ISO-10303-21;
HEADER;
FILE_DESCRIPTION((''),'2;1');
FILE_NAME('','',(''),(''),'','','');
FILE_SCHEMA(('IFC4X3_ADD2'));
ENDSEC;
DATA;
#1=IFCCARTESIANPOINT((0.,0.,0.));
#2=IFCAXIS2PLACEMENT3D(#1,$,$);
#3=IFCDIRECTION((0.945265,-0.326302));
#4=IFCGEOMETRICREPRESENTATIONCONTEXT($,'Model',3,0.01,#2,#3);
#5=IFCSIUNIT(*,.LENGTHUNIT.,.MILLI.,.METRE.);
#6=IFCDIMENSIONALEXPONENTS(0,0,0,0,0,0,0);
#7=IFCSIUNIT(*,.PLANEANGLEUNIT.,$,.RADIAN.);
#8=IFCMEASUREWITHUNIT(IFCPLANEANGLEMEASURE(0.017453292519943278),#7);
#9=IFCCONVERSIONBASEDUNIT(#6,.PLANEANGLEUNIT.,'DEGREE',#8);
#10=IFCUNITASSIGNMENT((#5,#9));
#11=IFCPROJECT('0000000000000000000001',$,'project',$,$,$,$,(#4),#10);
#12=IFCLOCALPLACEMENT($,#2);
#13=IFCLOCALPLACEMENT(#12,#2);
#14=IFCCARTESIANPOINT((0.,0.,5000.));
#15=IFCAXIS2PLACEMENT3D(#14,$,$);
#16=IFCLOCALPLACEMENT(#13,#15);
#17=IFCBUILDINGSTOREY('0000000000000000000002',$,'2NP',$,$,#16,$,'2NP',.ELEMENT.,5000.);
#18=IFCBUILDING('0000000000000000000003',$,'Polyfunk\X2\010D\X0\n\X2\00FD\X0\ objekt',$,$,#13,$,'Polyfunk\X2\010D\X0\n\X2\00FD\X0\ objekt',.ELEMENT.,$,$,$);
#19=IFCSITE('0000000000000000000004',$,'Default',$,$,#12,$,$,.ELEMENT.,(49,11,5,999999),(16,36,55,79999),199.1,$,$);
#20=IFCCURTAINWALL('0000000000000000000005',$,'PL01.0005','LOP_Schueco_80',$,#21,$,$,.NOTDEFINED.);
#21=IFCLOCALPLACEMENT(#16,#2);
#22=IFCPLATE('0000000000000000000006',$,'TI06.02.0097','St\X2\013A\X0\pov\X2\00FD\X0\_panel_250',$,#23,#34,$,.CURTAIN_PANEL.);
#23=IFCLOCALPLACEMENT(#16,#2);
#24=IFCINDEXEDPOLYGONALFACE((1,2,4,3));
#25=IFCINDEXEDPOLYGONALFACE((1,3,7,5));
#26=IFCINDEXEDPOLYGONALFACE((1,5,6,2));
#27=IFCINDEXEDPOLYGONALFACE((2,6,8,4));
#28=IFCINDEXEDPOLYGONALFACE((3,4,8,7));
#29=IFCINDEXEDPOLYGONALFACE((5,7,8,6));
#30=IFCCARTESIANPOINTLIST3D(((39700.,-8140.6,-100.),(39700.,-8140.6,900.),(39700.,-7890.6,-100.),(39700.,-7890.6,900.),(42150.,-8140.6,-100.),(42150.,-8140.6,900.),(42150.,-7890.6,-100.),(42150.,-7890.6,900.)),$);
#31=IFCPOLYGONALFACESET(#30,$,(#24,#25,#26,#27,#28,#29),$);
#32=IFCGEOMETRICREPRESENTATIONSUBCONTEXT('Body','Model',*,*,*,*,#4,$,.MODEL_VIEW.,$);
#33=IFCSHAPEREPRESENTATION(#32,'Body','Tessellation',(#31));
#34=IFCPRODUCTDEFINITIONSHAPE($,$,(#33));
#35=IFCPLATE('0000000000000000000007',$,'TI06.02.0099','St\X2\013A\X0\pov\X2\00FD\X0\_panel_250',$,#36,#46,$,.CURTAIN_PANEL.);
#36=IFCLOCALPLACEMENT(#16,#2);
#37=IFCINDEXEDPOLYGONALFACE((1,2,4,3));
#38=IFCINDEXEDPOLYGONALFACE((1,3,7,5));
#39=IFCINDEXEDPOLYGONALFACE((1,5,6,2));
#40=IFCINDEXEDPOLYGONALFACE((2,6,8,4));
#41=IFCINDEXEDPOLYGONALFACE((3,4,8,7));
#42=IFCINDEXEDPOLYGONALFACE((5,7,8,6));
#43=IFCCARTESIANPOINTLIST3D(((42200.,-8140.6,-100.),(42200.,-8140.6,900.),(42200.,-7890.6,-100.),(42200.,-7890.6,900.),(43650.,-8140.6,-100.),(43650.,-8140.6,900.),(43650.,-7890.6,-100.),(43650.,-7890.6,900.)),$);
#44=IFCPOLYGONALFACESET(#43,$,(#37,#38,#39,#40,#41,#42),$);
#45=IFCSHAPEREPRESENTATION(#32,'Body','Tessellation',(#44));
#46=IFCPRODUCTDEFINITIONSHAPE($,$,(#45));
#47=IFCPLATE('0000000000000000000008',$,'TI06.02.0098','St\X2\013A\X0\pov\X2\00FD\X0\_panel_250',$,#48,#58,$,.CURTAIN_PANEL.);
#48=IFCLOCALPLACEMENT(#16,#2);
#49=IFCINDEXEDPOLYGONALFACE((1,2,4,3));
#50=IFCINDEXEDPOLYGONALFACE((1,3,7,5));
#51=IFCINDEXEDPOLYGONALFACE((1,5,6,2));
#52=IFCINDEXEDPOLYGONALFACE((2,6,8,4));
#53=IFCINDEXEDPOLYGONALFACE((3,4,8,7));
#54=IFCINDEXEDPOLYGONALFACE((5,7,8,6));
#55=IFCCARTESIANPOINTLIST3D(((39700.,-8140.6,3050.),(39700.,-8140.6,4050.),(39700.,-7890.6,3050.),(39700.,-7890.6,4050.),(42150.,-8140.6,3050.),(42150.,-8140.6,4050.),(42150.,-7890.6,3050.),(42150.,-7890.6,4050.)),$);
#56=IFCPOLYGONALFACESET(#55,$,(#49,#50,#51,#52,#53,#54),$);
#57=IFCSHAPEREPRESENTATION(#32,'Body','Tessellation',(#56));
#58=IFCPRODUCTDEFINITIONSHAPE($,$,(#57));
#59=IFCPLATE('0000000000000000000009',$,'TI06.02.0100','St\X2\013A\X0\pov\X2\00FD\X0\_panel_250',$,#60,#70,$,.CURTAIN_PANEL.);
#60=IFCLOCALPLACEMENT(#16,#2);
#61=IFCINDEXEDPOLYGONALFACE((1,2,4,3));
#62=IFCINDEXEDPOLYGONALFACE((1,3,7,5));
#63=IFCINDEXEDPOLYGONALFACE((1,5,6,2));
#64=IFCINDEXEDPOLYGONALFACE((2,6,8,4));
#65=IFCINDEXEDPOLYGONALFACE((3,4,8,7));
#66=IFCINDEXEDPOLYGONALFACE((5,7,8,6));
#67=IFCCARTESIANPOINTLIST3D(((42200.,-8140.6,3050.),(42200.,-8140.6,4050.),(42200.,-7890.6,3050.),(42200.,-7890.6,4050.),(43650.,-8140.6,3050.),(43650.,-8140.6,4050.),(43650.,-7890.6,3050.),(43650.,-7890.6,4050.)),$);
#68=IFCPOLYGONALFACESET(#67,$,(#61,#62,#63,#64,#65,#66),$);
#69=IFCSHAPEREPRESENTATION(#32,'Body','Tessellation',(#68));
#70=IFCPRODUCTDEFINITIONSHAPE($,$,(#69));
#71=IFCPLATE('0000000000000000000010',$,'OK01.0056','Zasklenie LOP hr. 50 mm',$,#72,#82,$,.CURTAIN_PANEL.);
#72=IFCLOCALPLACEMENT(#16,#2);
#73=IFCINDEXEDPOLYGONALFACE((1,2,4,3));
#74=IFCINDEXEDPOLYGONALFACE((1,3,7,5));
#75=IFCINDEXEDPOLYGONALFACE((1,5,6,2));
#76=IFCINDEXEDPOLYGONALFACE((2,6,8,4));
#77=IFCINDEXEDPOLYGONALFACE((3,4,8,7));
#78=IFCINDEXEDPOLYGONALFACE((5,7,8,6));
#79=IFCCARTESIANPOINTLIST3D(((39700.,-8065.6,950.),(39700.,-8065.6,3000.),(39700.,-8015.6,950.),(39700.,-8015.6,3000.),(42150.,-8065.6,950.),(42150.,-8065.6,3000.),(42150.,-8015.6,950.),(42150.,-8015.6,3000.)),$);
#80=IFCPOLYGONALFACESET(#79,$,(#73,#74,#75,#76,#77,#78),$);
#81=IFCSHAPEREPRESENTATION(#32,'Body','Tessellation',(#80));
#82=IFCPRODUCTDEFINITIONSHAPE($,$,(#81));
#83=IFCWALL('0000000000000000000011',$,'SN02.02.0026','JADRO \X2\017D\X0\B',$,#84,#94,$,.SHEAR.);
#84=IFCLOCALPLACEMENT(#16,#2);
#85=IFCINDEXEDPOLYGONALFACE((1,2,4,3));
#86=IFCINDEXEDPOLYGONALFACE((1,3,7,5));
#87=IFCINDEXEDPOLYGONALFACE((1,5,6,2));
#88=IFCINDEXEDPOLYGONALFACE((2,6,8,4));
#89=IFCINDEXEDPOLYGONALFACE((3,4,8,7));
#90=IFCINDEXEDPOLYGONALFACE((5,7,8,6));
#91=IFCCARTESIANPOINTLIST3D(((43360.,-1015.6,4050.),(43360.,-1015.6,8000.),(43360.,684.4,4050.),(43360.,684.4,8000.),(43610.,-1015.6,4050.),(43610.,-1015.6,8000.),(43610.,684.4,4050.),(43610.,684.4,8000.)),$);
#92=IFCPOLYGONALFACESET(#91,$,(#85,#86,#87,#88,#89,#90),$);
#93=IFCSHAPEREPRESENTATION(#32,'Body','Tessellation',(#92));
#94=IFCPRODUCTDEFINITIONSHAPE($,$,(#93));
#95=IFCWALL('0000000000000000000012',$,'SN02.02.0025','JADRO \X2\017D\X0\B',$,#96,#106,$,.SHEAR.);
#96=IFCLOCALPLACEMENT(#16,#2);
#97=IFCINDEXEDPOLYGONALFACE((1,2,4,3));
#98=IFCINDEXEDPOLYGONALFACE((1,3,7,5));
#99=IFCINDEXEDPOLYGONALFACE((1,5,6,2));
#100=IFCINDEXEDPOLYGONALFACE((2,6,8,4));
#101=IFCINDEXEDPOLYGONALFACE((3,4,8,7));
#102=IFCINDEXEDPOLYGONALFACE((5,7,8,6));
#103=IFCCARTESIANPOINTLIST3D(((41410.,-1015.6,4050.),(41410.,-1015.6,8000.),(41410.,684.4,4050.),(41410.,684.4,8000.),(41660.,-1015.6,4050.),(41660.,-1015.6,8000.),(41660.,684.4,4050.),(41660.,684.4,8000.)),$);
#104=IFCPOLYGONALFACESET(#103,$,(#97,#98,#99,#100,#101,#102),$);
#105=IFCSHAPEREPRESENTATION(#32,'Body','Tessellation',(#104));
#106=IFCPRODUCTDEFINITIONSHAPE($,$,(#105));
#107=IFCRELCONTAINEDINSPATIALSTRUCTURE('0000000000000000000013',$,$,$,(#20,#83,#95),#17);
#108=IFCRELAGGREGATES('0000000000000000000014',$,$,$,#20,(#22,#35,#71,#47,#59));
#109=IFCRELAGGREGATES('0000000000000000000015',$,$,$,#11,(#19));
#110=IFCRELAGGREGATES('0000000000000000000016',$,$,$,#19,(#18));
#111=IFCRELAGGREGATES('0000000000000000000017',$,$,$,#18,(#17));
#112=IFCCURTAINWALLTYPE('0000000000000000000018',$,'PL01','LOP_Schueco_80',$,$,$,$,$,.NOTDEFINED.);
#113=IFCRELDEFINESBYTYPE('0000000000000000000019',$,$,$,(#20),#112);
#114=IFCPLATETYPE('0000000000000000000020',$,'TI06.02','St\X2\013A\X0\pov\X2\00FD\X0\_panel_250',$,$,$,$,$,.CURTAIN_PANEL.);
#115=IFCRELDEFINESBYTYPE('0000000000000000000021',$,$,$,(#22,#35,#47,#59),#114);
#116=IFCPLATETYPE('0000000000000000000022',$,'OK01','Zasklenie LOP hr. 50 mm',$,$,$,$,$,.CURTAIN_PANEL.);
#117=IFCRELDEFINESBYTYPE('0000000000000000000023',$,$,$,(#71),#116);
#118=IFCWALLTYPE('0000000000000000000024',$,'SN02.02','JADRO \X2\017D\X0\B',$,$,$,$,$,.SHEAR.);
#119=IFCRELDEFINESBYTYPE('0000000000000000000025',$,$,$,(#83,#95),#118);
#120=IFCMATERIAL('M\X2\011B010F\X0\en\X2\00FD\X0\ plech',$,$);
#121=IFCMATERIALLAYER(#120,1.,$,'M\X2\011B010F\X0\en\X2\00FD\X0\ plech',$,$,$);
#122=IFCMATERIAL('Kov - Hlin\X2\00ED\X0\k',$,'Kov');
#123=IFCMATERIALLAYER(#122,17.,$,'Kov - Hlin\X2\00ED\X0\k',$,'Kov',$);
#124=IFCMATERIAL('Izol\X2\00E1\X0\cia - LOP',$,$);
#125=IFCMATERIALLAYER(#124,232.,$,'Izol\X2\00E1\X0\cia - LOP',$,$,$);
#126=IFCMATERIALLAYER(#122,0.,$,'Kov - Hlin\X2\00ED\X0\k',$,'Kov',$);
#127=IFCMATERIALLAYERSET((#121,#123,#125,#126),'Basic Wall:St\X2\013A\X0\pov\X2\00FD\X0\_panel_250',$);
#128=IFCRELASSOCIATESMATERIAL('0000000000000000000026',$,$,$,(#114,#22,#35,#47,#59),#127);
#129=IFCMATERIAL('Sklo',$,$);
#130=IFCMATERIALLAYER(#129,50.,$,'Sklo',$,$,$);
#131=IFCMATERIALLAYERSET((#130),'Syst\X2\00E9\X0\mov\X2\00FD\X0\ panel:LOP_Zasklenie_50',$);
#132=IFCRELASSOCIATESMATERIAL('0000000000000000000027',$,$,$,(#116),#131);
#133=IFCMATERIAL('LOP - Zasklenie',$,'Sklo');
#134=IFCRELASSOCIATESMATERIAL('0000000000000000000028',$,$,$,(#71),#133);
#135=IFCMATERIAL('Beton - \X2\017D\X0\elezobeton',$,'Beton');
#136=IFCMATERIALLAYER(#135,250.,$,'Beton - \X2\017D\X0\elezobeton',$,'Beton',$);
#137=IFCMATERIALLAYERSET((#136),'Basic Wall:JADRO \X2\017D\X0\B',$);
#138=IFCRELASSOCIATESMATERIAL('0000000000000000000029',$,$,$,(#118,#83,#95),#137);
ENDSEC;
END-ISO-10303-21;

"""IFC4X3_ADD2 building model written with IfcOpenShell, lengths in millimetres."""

from ifc_helpers import new_model, entity, si_unit, converted_unit, direction, frame, frame_2d, origin, origin_2d_with_axis, place, context, subcontext, project, spatial, polyline, rectangle, extrude, clip, bounded_halfspace, source, transform, mapped, material, layer, layer_set, layer_usage, type_object, type_shapes, element, aggregate, save


model = new_model("IFC4X3_ADD2")

# Units and contexts
model_context = context("Model", 3, precision=0.01, world=origin(), true_north=direction((0.945265, -0.326302)))
body_context = subcontext(model_context, "Body", "Model", "MODEL_VIEW")
ifc_project = project(units=[si_unit("LENGTHUNIT", "METRE", prefix="MILLI"), converted_unit("PLANEANGLEUNIT", "DEGREE", entity("IfcPlaneAngleMeasure", 0.017453292519943278), si_unit("PLANEANGLEUNIT", "RADIAN"), dimensions=[0, 0, 0, 0, 0, 0, 0])], contexts=[model_context])

# Site, building, storey
site_placement = place(None, origin())
site = spatial("IfcSite", under=ifc_project, at=site_placement, Name="Default", CompositionType="ELEMENT", RefLatitude=(49, 11, 5, 999999), RefLongitude=(16, 36, 55, 79999), RefElevation=199.1)
building_placement = place(site_placement, origin())
building = spatial("IfcBuilding", under=site, at=building_placement, Name="Polyfunkčný objekt", LongName="Polyfunkčný objekt", CompositionType="ELEMENT")
storey_placement = place(building_placement, frame((0.0, 0.0, 5000.0)))
storey = spatial("IfcBuildingStorey", under=building, at=storey_placement, Name="2NP", LongName="2NP", CompositionType="ELEMENT", Elevation=5000.0)

# Curtain wall, plates
curtain_wall_type = type_object("IfcCurtainWallType", Name="PL01", Description="LOP_Schueco_80", PredefinedType="NOTDEFINED")
curtain_wall_placement = place(storey_placement, frame((0.0, 0.0, -5000.0)))
curtain_wall = element("IfcCurtainWall", 1, at=curtain_wall_placement, inside=storey, type_object=curtain_wall_type, Name="PL01.0005", Description="LOP_Schueco_80", PredefinedType="NOTDEFINED")
ifc_material_1 = material(Name="Měďený plech")
ifc_layer_1 = layer(ifc_material_1, 1.0, Name="Měďený plech")
ifc_material_2 = material(Name="Kov - Hliník", Category="Kov")
ifc_layer_2 = layer(ifc_material_2, 17.0, Name="Kov - Hliník", Category="Kov")
ifc_material_3 = material(Name="Izolácia - LOP")
ifc_layer_3 = layer(ifc_material_3, 232.0, Name="Izolácia - LOP")
ifc_layer_4 = layer(ifc_material_2, 0.0, Name="Kov - Hliník", Category="Kov")
ifc_layer_set_1 = layer_set([ifc_layer_1, ifc_layer_2, ifc_layer_3, ifc_layer_4], Name="Basic Wall:Stĺpový_panel_250")
ifc_layer_usage_1 = layer_usage(ifc_layer_set_1, "AXIS2", "POSITIVE", -125.0)
plate_type_1 = type_object("IfcPlateType", Name="TI06.02", Description="Stĺpový_panel_250", PredefinedType="CURTAIN_PANEL", material=ifc_layer_set_1)
plate_1_placement = place(storey_placement, frame((39700.0, -8015.6, -100.0)))
plate_1 = element("IfcPlate", 2, at=plate_1_placement, type_object=plate_type_1, material=ifc_layer_usage_1, Name="TI06.02.0097", Description="Stĺpový_panel_250", PredefinedType="CURTAIN_PANEL", context=body_context, shape_type="SweptSolid", body=[
    extrude(rectangle(XDim=250.0, YDim=2450.0, at=frame_2d((0.0, 0.0), x_axis=(1.0, 0.0))), frame((1225.0, 0.0, 0.0), z_axis=(0.0, 0.0, 1.0), x_axis=(0.0, 1.0, 0.0)), (0.0, 0.0, 1.0), 1000.0),
])
ifc_layer_usage_2 = layer_usage(ifc_layer_set_1, "AXIS2", "POSITIVE", -125.0)
plate_2_placement = place(storey_placement, frame((42200.0, -8015.6, -100.0)))
plate_2 = element("IfcPlate", 3, at=plate_2_placement, type_object=plate_type_1, material=ifc_layer_usage_2, Name="TI06.02.0099", Description="Stĺpový_panel_250", PredefinedType="CURTAIN_PANEL", context=body_context, shape_type="SweptSolid", body=[
    extrude(rectangle(XDim=250.0, YDim=1450.0, at=frame_2d((0.0, 0.0), x_axis=(1.0, 0.0))), frame((725.0, 0.0, 0.0), z_axis=(0.0, 0.0, 1.0), x_axis=(0.0, 1.0, 0.0)), (0.0, 0.0, 1.0), 1000.0),
])
ifc_layer_usage_3 = layer_usage(ifc_layer_set_1, "AXIS2", "POSITIVE", -125.0)
plate_3_placement = place(storey_placement, frame((39700.0, -8015.6, 3050.0)))
plate_3 = element("IfcPlate", 4, at=plate_3_placement, type_object=plate_type_1, material=ifc_layer_usage_3, Name="TI06.02.0098", Description="Stĺpový_panel_250", PredefinedType="CURTAIN_PANEL", context=body_context, shape_type="SweptSolid", body=[
    extrude(rectangle(XDim=250.0, YDim=2450.0, at=frame_2d((0.0, 0.0), x_axis=(1.0, 0.0))), frame((1225.0, 0.0, 0.0), z_axis=(0.0, 0.0, 1.0), x_axis=(0.0, 1.0, 0.0)), (0.0, 0.0, 1.0), 1000.0),
])
ifc_layer_usage_4 = layer_usage(ifc_layer_set_1, "AXIS2", "POSITIVE", -125.0)
plate_4_placement = place(storey_placement, frame((42200.0, -8015.6, 3050.0)))
plate_4 = element("IfcPlate", 5, at=plate_4_placement, type_object=plate_type_1, material=ifc_layer_usage_4, Name="TI06.02.0100", Description="Stĺpový_panel_250", PredefinedType="CURTAIN_PANEL", context=body_context, shape_type="SweptSolid", body=[
    extrude(rectangle(XDim=250.0, YDim=1450.0, at=frame_2d((0.0, 0.0), x_axis=(1.0, 0.0))), frame((725.0, 0.0, 0.0), z_axis=(0.0, 0.0, 1.0), x_axis=(0.0, 1.0, 0.0)), (0.0, 0.0, 1.0), 1000.0),
])
ifc_material_4 = material(Name="LOP - Zasklenie", Category="Sklo")
ifc_material_5 = material(Name="Sklo")
ifc_layer_5 = layer(ifc_material_5, 50.0, Name="Sklo")
ifc_layer_set_2 = layer_set([ifc_layer_5], Name="Systémový panel:LOP_Zasklenie_50")
plate_type_2 = type_object("IfcPlateType", Name="OK01", Description="Zasklenie LOP hr. 50 mm", PredefinedType="CURTAIN_PANEL", material=ifc_layer_set_2)
shared_shape_1 = source(origin(), body_context, "Body", "SweptSolid", [
    extrude(rectangle(XDim=50.0, YDim=2450.0, at=origin_2d_with_axis()), frame((0.0, -25.0, 0.0), z_axis=(0.0, 0.0, 1.0), x_axis=(0.0, 1.0, 0.0)), (0.0, 0.0, 1.0), 2050.0),
])
type_shapes(plate_type_2, [shared_shape_1])
plate_5_placement = place(curtain_wall_placement, frame((40925.0, -8015.6, 5950.0)))
plate_5 = element("IfcPlate", 6, at=plate_5_placement, type_object=plate_type_2, material=ifc_material_4, Name="OK01.0056", Description="Zasklenie LOP hr. 50 mm", PredefinedType="CURTAIN_PANEL", context=body_context, shape_type="MappedRepresentation", body=[
    mapped(shared_shape_1, transform((0.0, 0.0, 0.0), scale=1.0)),
])
aggregate(curtain_wall, [plate_1, plate_2, plate_5, plate_3, plate_4])

# Walls
ifc_material_6 = material(Name="Beton - Železobeton", Category="Beton")
ifc_layer_6 = layer(ifc_material_6, 250.0, Name="Beton - Železobeton", Category="Beton")
ifc_layer_set_3 = layer_set([ifc_layer_6], Name="Basic Wall:JADRO ŽB")
wall_type = type_object("IfcWallType", Name="SN02.02", Description="JADRO ŽB", PredefinedType="SHEAR", material=ifc_layer_set_3)
wall_1_placement = place(storey_placement, frame((43485.0, 684.4, 4050.0), z_axis=(0.0, 0.0, 1.0), x_axis=(0.0, -1.0, 0.0)))
element("IfcWall", 7, at=wall_1_placement, inside=storey, type_object=wall_type, material=ifc_layer_set_3, Name="SN02.02.0026", Description="JADRO ŽB", PredefinedType="SHEAR", context=body_context, shape_type="Clipping", body=[
    clip(clip(extrude(rectangle(XDim=1700.0, YDim=250.0, at=frame_2d((850.0, 0.0), x_axis=(-1.0, 0.0))), origin(), (0.0, 0.0, 1.0), 3950.0), bounded_halfspace(frame((1700.0, -125.0, 0.0), z_axis=(0.0, 0.0, 1.0), x_axis=(0.0, -1.0, 0.0)), True, frame((1700.0, -125.0, 0.0)), polyline([(0.0, 0.0), (0.0, 250.0), (-1700.0, 250.0), (-1700.0, 0.0), (0.0, 0.0)]))), bounded_halfspace(frame((0.0, -125.0, 3950.0), z_axis=(0.0, 0.0, -1.0), x_axis=(0.0, 1.0, 0.0)), True, frame((0.0, -125.0, 3950.0)), polyline([(0.0, 0.0), (1700.0, 0.0), (1700.0, 250.0), (0.0, 250.0), (0.0, 0.0)]))),
])
wall_2_placement = place(storey_placement, frame((41535.0, 684.4, 4050.0), z_axis=(0.0, 0.0, 1.0), x_axis=(0.0, -1.0, 0.0)))
element("IfcWall", 8, at=wall_2_placement, inside=storey, type_object=wall_type, material=ifc_layer_set_3, Name="SN02.02.0025", Description="JADRO ŽB", PredefinedType="SHEAR", context=body_context, shape_type="Clipping", body=[
    clip(clip(extrude(rectangle(XDim=1700.0, YDim=250.0, at=frame_2d((850.0, 0.0), x_axis=(-1.0, 0.0))), origin(), (0.0, 0.0, 1.0), 3950.0), bounded_halfspace(frame((1700.0, -125.0, 0.0), z_axis=(0.0, 0.0, 1.0), x_axis=(0.0, -1.0, 0.0)), True, frame((1700.0, -125.0, 0.0)), polyline([(0.0, 0.0), (0.0, 250.0), (-1700.0, 250.0), (-1700.0, 0.0), (0.0, 0.0)]))), bounded_halfspace(frame((0.0, -125.0, 3950.0), z_axis=(0.0, 0.0, -1.0), x_axis=(0.0, 1.0, 0.0)), True, frame((0.0, -125.0, 3950.0)), polyline([(0.0, 0.0), (1700.0, 0.0), (1700.0, 250.0), (0.0, 250.0), (0.0, 0.0)]))),
])

save(model, "model.ifc")
